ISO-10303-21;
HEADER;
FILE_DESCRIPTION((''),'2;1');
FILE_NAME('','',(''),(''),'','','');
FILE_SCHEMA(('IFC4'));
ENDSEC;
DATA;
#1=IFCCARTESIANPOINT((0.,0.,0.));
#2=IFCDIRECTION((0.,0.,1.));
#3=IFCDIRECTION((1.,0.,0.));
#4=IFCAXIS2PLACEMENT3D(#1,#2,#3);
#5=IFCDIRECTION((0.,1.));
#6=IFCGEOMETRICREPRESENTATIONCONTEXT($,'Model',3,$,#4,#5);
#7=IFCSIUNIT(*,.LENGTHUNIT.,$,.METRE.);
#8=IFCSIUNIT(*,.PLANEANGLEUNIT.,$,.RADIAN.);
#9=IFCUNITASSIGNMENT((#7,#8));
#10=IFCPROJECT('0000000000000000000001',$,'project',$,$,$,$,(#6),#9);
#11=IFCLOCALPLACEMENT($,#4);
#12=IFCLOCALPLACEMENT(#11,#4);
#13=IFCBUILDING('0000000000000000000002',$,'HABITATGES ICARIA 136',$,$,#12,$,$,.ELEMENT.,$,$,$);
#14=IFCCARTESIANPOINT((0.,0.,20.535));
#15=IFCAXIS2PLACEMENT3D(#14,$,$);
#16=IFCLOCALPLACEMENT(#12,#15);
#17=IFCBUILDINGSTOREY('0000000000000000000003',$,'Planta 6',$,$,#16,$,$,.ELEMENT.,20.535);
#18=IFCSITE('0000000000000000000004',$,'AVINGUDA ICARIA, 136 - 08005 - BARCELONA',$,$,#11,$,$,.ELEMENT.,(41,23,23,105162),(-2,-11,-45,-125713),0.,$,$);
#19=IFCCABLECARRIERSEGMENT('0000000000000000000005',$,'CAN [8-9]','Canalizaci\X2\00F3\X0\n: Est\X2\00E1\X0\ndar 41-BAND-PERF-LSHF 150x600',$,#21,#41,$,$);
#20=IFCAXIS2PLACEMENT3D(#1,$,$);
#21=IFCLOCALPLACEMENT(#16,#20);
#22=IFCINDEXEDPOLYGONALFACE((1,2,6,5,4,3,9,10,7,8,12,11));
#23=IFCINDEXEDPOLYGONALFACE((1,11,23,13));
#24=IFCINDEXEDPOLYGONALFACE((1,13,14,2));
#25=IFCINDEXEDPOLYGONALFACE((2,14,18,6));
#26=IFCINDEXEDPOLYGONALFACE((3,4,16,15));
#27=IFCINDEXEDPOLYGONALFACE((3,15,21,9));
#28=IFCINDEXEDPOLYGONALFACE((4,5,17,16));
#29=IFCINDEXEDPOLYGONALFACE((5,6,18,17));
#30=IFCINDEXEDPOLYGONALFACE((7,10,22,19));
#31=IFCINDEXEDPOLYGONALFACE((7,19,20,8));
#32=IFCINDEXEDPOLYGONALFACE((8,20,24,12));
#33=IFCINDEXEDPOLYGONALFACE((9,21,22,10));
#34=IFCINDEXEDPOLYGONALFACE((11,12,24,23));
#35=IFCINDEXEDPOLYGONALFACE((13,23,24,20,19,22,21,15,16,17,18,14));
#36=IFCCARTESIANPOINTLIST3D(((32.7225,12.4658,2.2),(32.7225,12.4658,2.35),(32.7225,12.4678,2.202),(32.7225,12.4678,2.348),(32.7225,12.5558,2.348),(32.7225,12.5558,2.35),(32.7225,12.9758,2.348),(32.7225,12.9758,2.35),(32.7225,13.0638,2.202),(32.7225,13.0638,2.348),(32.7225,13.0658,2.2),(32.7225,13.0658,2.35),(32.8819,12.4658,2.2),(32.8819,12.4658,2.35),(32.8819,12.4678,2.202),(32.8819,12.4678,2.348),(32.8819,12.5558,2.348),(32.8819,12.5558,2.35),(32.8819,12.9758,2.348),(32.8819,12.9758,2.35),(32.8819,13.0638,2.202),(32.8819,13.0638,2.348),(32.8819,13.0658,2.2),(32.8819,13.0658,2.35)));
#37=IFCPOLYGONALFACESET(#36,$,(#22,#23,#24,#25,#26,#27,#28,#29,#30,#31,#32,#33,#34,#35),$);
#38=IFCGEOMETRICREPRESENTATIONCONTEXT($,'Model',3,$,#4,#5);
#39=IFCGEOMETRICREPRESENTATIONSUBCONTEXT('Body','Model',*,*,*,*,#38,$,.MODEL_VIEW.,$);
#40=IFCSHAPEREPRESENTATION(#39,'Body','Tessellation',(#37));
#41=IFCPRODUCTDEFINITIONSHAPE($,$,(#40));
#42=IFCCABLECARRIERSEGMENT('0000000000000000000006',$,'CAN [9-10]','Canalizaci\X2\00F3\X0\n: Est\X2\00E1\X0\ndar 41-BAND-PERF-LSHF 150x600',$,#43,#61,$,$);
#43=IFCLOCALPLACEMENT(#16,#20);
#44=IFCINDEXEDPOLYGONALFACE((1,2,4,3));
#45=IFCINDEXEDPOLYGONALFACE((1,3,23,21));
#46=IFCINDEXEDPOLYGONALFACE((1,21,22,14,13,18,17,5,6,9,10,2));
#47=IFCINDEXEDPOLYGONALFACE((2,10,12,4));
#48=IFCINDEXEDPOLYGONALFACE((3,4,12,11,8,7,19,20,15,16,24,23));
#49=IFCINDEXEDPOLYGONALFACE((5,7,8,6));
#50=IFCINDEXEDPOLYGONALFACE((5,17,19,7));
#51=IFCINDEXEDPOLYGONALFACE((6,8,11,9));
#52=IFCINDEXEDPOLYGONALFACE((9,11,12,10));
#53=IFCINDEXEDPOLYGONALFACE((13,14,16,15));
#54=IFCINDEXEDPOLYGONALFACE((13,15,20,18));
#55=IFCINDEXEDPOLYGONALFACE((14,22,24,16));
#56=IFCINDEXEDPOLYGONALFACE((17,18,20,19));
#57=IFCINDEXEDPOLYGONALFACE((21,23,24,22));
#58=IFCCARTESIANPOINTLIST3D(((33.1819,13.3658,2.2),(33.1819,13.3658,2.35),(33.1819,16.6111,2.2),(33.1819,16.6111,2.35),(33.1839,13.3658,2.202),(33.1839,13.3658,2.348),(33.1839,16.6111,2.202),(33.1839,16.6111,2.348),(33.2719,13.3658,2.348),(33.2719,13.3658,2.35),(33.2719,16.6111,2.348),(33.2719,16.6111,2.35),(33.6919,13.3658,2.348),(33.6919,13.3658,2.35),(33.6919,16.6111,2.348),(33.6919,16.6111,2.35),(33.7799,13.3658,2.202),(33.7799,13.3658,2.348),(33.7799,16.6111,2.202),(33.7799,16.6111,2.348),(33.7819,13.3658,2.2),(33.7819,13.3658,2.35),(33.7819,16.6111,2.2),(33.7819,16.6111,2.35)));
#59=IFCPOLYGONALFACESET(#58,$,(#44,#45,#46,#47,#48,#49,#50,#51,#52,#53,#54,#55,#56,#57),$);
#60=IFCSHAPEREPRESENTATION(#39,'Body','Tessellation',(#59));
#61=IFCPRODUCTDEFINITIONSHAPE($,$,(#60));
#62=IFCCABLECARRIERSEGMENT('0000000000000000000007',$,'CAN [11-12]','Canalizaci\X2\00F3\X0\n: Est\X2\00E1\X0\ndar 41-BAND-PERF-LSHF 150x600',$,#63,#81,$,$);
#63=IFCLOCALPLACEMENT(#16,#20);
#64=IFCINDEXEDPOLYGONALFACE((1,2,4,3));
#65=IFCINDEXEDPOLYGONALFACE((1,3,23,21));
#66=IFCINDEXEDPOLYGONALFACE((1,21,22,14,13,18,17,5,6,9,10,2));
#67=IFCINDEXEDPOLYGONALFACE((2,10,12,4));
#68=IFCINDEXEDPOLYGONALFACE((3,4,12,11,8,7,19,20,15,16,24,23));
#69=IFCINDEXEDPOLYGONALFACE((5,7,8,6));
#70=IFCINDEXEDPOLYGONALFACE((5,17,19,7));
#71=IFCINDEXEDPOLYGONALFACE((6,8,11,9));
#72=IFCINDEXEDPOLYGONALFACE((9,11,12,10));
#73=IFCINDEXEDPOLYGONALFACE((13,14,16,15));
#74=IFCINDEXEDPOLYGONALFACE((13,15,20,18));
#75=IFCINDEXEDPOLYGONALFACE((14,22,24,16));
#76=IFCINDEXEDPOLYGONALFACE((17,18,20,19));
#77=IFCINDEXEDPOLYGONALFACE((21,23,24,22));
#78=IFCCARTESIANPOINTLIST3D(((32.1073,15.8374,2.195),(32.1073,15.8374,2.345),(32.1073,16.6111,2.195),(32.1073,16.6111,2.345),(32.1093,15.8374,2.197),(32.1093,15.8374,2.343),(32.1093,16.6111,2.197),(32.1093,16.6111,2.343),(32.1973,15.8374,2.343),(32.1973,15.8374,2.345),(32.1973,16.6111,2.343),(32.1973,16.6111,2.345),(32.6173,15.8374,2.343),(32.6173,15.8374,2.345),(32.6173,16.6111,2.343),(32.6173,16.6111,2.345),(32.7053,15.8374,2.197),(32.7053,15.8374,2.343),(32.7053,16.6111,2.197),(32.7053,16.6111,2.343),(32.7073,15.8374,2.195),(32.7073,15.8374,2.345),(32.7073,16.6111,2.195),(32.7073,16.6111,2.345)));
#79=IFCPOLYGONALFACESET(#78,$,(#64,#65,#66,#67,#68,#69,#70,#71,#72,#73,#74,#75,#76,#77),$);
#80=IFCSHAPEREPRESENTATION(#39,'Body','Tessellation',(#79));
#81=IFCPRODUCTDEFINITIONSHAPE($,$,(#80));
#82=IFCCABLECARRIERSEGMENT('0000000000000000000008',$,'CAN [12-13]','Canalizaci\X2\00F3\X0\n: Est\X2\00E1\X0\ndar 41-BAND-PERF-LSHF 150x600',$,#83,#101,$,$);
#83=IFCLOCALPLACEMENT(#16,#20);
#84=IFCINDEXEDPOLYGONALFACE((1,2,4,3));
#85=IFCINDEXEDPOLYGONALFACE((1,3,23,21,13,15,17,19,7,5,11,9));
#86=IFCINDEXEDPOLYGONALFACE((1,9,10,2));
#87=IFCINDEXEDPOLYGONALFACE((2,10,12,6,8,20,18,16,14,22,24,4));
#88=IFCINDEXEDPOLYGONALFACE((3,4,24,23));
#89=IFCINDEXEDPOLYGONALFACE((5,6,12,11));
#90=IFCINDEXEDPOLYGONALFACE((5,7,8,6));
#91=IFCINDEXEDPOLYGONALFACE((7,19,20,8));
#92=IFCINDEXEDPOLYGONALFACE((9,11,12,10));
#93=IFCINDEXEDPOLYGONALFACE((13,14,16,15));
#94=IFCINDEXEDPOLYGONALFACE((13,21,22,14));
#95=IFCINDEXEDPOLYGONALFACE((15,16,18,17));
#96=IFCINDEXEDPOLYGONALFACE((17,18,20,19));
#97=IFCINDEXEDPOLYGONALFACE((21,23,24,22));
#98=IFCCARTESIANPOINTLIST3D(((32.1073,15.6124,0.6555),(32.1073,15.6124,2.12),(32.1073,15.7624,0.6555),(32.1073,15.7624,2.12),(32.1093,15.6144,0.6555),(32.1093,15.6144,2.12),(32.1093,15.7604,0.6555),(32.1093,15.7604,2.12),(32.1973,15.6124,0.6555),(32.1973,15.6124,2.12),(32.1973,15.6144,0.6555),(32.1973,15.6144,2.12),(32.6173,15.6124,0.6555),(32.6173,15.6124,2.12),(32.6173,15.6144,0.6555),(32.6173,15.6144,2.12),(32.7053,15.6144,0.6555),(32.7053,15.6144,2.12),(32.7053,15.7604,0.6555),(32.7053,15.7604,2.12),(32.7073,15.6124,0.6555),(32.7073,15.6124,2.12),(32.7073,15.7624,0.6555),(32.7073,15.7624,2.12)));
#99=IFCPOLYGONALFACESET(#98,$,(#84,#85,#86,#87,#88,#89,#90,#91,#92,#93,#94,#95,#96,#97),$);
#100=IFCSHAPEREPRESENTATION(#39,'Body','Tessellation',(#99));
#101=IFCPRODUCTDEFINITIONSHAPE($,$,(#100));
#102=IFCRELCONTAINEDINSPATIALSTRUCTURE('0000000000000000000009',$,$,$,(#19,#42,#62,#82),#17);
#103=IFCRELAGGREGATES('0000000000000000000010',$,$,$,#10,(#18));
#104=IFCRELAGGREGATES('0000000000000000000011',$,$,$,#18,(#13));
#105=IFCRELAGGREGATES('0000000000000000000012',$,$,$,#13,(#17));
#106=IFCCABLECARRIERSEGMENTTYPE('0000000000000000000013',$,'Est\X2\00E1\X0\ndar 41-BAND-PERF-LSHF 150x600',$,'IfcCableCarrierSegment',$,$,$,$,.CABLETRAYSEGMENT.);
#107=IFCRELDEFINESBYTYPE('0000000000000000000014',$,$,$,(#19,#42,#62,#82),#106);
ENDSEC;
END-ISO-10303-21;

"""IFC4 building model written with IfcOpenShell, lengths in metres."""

from ifc_helpers import new_model, si_unit, direction, frame, origin_with_axes, place, context, subcontext, project, spatial, polyline, outline, extrude, type_object, element, save


model = new_model("IFC4")

# Units and contexts
model_context_1 = context("Model", 3, world=origin_with_axes(), true_north=direction((0.0, 1.0)))
model_context_2 = context("Model", 3, world=origin_with_axes(), true_north=direction((0.0, 1.0)))
body_context_1 = subcontext(model_context_2, "Body", "Model", "MODEL_VIEW")
ifc_project = project(units=[si_unit("LENGTHUNIT", "METRE"), si_unit("PLANEANGLEUNIT", "RADIAN")], contexts=[model_context_1])

# Site, building, storey
site_placement = place(None, origin_with_axes())
site = spatial("IfcSite", under=ifc_project, at=site_placement, Name="AVINGUDA ICARIA, 136 - 08005 - BARCELONA", CompositionType="ELEMENT", RefLatitude=(41, 23, 23, 105162), RefLongitude=(-2, -11, -45, -125713), RefElevation=0.0)
building_placement = place(site_placement, origin_with_axes())
building = spatial("IfcBuilding", under=site, at=building_placement, Name="HABITATGES ICARIA 136", CompositionType="ELEMENT")
storey_placement = place(building_placement, frame((0.0, 0.0, 20.535)))
storey = spatial("IfcBuildingStorey", under=building, at=storey_placement, Name="Planta 6", CompositionType="ELEMENT", Elevation=20.535)

# Cable carrier segments
cable_carrier_segment_type = type_object("IfcCableCarrierSegmentType", Name="Estándar 41-BAND-PERF-LSHF 150x600", ApplicableOccurrence="IfcCableCarrierSegment", PredefinedType="CABLETRAYSEGMENT")
placement_1 = place(None, origin_with_axes())
placement_2 = place(placement_1, origin_with_axes())
placement_3 = place(placement_2, frame((0.0, 0.0, 20.535)))
cable_carrier_segment_1_placement = place(placement_3, origin_with_axes())
element("IfcCableCarrierSegment", 1, at=cable_carrier_segment_1_placement, inside=storey, type_object=cable_carrier_segment_type, Name="CAN [8-9]", Description="Canalización: Estándar 41-BAND-PERF-LSHF 150x600", context=body_context_1, shape_type="SweptSolid", body=[
    extrude(outline(polyline([(-0.21, 0.148), (-0.21, 0.15), (-0.3, 0.15), (-0.3, 0.0), (0.3, 0.0), (0.3, 0.15), (0.21, 0.15), (0.21, 0.148), (0.298, 0.148), (0.298, 0.002), (-0.298, 0.002), (-0.298, 0.148), (-0.21, 0.148)])), frame((32.7225, 12.7658, 2.2), z_axis=(1.0, 0.0, 0.0), x_axis=(0.0, 1.0, 0.0)), (0.0, 0.0, 1.0), 0.1594),
])
cable_carrier_segment_2_placement = place(placement_3, origin_with_axes())
element("IfcCableCarrierSegment", 2, at=cable_carrier_segment_2_placement, inside=storey, type_object=cable_carrier_segment_type, Name="CAN [9-10]", Description="Canalización: Estándar 41-BAND-PERF-LSHF 150x600", context=body_context_1, shape_type="SweptSolid", body=[
    extrude(outline(polyline([(-0.21, 0.148), (-0.21, 0.15), (-0.3, 0.15), (-0.3, 0.0), (0.3, 0.0), (0.3, 0.15), (0.21, 0.15), (0.21, 0.148), (0.298, 0.148), (0.298, 0.002), (-0.298, 0.002), (-0.298, 0.148), (-0.21, 0.148)])), frame((33.4819, 13.3658, 2.2), z_axis=(0.0, 1.0, 0.0), x_axis=(-1.0, 0.0, 0.0)), (0.0, 0.0, 1.0), 3.2454),
])
cable_carrier_segment_3_placement = place(placement_3, origin_with_axes())
element("IfcCableCarrierSegment", 3, at=cable_carrier_segment_3_placement, inside=storey, type_object=cable_carrier_segment_type, Name="CAN [11-12]", Description="Canalización: Estándar 41-BAND-PERF-LSHF 150x600", context=body_context_1, shape_type="SweptSolid", body=[
    extrude(outline(polyline([(-0.21, 0.148), (-0.21, 0.15), (-0.3, 0.15), (-0.3, 0.0), (0.3, 0.0), (0.3, 0.15), (0.21, 0.15), (0.21, 0.148), (0.298, 0.148), (0.298, 0.002), (-0.298, 0.002), (-0.298, 0.148), (-0.21, 0.148)])), frame((32.4073, 16.6111, 2.195), z_axis=(0.0, -1.0, 0.0), x_axis=(1.0, 0.0, 0.0)), (0.0, 0.0, 1.0), 0.7737),
])
cable_carrier_segment_4_placement = place(placement_3, origin_with_axes())
element("IfcCableCarrierSegment", 4, at=cable_carrier_segment_4_placement, inside=storey, type_object=cable_carrier_segment_type, Name="CAN [12-13]", Description="Canalización: Estándar 41-BAND-PERF-LSHF 150x600", context=body_context_1, shape_type="SweptSolid", body=[
    extrude(outline(polyline([(-0.21, 0.148), (-0.21, 0.15), (-0.3, 0.15), (-0.3, 0.0), (0.3, 0.0), (0.3, 0.15), (0.21, 0.15), (0.21, 0.148), (0.298, 0.148), (0.298, 0.002), (-0.298, 0.002), (-0.298, 0.148), (-0.21, 0.148)])), frame((32.4073, 15.7624, 2.12), z_axis=(0.0, 0.0, -1.0), x_axis=(1.0, 0.0, 0.0)), (0.0, 0.0, 1.0), 1.4645),
])

save(model, "model.ifc")
